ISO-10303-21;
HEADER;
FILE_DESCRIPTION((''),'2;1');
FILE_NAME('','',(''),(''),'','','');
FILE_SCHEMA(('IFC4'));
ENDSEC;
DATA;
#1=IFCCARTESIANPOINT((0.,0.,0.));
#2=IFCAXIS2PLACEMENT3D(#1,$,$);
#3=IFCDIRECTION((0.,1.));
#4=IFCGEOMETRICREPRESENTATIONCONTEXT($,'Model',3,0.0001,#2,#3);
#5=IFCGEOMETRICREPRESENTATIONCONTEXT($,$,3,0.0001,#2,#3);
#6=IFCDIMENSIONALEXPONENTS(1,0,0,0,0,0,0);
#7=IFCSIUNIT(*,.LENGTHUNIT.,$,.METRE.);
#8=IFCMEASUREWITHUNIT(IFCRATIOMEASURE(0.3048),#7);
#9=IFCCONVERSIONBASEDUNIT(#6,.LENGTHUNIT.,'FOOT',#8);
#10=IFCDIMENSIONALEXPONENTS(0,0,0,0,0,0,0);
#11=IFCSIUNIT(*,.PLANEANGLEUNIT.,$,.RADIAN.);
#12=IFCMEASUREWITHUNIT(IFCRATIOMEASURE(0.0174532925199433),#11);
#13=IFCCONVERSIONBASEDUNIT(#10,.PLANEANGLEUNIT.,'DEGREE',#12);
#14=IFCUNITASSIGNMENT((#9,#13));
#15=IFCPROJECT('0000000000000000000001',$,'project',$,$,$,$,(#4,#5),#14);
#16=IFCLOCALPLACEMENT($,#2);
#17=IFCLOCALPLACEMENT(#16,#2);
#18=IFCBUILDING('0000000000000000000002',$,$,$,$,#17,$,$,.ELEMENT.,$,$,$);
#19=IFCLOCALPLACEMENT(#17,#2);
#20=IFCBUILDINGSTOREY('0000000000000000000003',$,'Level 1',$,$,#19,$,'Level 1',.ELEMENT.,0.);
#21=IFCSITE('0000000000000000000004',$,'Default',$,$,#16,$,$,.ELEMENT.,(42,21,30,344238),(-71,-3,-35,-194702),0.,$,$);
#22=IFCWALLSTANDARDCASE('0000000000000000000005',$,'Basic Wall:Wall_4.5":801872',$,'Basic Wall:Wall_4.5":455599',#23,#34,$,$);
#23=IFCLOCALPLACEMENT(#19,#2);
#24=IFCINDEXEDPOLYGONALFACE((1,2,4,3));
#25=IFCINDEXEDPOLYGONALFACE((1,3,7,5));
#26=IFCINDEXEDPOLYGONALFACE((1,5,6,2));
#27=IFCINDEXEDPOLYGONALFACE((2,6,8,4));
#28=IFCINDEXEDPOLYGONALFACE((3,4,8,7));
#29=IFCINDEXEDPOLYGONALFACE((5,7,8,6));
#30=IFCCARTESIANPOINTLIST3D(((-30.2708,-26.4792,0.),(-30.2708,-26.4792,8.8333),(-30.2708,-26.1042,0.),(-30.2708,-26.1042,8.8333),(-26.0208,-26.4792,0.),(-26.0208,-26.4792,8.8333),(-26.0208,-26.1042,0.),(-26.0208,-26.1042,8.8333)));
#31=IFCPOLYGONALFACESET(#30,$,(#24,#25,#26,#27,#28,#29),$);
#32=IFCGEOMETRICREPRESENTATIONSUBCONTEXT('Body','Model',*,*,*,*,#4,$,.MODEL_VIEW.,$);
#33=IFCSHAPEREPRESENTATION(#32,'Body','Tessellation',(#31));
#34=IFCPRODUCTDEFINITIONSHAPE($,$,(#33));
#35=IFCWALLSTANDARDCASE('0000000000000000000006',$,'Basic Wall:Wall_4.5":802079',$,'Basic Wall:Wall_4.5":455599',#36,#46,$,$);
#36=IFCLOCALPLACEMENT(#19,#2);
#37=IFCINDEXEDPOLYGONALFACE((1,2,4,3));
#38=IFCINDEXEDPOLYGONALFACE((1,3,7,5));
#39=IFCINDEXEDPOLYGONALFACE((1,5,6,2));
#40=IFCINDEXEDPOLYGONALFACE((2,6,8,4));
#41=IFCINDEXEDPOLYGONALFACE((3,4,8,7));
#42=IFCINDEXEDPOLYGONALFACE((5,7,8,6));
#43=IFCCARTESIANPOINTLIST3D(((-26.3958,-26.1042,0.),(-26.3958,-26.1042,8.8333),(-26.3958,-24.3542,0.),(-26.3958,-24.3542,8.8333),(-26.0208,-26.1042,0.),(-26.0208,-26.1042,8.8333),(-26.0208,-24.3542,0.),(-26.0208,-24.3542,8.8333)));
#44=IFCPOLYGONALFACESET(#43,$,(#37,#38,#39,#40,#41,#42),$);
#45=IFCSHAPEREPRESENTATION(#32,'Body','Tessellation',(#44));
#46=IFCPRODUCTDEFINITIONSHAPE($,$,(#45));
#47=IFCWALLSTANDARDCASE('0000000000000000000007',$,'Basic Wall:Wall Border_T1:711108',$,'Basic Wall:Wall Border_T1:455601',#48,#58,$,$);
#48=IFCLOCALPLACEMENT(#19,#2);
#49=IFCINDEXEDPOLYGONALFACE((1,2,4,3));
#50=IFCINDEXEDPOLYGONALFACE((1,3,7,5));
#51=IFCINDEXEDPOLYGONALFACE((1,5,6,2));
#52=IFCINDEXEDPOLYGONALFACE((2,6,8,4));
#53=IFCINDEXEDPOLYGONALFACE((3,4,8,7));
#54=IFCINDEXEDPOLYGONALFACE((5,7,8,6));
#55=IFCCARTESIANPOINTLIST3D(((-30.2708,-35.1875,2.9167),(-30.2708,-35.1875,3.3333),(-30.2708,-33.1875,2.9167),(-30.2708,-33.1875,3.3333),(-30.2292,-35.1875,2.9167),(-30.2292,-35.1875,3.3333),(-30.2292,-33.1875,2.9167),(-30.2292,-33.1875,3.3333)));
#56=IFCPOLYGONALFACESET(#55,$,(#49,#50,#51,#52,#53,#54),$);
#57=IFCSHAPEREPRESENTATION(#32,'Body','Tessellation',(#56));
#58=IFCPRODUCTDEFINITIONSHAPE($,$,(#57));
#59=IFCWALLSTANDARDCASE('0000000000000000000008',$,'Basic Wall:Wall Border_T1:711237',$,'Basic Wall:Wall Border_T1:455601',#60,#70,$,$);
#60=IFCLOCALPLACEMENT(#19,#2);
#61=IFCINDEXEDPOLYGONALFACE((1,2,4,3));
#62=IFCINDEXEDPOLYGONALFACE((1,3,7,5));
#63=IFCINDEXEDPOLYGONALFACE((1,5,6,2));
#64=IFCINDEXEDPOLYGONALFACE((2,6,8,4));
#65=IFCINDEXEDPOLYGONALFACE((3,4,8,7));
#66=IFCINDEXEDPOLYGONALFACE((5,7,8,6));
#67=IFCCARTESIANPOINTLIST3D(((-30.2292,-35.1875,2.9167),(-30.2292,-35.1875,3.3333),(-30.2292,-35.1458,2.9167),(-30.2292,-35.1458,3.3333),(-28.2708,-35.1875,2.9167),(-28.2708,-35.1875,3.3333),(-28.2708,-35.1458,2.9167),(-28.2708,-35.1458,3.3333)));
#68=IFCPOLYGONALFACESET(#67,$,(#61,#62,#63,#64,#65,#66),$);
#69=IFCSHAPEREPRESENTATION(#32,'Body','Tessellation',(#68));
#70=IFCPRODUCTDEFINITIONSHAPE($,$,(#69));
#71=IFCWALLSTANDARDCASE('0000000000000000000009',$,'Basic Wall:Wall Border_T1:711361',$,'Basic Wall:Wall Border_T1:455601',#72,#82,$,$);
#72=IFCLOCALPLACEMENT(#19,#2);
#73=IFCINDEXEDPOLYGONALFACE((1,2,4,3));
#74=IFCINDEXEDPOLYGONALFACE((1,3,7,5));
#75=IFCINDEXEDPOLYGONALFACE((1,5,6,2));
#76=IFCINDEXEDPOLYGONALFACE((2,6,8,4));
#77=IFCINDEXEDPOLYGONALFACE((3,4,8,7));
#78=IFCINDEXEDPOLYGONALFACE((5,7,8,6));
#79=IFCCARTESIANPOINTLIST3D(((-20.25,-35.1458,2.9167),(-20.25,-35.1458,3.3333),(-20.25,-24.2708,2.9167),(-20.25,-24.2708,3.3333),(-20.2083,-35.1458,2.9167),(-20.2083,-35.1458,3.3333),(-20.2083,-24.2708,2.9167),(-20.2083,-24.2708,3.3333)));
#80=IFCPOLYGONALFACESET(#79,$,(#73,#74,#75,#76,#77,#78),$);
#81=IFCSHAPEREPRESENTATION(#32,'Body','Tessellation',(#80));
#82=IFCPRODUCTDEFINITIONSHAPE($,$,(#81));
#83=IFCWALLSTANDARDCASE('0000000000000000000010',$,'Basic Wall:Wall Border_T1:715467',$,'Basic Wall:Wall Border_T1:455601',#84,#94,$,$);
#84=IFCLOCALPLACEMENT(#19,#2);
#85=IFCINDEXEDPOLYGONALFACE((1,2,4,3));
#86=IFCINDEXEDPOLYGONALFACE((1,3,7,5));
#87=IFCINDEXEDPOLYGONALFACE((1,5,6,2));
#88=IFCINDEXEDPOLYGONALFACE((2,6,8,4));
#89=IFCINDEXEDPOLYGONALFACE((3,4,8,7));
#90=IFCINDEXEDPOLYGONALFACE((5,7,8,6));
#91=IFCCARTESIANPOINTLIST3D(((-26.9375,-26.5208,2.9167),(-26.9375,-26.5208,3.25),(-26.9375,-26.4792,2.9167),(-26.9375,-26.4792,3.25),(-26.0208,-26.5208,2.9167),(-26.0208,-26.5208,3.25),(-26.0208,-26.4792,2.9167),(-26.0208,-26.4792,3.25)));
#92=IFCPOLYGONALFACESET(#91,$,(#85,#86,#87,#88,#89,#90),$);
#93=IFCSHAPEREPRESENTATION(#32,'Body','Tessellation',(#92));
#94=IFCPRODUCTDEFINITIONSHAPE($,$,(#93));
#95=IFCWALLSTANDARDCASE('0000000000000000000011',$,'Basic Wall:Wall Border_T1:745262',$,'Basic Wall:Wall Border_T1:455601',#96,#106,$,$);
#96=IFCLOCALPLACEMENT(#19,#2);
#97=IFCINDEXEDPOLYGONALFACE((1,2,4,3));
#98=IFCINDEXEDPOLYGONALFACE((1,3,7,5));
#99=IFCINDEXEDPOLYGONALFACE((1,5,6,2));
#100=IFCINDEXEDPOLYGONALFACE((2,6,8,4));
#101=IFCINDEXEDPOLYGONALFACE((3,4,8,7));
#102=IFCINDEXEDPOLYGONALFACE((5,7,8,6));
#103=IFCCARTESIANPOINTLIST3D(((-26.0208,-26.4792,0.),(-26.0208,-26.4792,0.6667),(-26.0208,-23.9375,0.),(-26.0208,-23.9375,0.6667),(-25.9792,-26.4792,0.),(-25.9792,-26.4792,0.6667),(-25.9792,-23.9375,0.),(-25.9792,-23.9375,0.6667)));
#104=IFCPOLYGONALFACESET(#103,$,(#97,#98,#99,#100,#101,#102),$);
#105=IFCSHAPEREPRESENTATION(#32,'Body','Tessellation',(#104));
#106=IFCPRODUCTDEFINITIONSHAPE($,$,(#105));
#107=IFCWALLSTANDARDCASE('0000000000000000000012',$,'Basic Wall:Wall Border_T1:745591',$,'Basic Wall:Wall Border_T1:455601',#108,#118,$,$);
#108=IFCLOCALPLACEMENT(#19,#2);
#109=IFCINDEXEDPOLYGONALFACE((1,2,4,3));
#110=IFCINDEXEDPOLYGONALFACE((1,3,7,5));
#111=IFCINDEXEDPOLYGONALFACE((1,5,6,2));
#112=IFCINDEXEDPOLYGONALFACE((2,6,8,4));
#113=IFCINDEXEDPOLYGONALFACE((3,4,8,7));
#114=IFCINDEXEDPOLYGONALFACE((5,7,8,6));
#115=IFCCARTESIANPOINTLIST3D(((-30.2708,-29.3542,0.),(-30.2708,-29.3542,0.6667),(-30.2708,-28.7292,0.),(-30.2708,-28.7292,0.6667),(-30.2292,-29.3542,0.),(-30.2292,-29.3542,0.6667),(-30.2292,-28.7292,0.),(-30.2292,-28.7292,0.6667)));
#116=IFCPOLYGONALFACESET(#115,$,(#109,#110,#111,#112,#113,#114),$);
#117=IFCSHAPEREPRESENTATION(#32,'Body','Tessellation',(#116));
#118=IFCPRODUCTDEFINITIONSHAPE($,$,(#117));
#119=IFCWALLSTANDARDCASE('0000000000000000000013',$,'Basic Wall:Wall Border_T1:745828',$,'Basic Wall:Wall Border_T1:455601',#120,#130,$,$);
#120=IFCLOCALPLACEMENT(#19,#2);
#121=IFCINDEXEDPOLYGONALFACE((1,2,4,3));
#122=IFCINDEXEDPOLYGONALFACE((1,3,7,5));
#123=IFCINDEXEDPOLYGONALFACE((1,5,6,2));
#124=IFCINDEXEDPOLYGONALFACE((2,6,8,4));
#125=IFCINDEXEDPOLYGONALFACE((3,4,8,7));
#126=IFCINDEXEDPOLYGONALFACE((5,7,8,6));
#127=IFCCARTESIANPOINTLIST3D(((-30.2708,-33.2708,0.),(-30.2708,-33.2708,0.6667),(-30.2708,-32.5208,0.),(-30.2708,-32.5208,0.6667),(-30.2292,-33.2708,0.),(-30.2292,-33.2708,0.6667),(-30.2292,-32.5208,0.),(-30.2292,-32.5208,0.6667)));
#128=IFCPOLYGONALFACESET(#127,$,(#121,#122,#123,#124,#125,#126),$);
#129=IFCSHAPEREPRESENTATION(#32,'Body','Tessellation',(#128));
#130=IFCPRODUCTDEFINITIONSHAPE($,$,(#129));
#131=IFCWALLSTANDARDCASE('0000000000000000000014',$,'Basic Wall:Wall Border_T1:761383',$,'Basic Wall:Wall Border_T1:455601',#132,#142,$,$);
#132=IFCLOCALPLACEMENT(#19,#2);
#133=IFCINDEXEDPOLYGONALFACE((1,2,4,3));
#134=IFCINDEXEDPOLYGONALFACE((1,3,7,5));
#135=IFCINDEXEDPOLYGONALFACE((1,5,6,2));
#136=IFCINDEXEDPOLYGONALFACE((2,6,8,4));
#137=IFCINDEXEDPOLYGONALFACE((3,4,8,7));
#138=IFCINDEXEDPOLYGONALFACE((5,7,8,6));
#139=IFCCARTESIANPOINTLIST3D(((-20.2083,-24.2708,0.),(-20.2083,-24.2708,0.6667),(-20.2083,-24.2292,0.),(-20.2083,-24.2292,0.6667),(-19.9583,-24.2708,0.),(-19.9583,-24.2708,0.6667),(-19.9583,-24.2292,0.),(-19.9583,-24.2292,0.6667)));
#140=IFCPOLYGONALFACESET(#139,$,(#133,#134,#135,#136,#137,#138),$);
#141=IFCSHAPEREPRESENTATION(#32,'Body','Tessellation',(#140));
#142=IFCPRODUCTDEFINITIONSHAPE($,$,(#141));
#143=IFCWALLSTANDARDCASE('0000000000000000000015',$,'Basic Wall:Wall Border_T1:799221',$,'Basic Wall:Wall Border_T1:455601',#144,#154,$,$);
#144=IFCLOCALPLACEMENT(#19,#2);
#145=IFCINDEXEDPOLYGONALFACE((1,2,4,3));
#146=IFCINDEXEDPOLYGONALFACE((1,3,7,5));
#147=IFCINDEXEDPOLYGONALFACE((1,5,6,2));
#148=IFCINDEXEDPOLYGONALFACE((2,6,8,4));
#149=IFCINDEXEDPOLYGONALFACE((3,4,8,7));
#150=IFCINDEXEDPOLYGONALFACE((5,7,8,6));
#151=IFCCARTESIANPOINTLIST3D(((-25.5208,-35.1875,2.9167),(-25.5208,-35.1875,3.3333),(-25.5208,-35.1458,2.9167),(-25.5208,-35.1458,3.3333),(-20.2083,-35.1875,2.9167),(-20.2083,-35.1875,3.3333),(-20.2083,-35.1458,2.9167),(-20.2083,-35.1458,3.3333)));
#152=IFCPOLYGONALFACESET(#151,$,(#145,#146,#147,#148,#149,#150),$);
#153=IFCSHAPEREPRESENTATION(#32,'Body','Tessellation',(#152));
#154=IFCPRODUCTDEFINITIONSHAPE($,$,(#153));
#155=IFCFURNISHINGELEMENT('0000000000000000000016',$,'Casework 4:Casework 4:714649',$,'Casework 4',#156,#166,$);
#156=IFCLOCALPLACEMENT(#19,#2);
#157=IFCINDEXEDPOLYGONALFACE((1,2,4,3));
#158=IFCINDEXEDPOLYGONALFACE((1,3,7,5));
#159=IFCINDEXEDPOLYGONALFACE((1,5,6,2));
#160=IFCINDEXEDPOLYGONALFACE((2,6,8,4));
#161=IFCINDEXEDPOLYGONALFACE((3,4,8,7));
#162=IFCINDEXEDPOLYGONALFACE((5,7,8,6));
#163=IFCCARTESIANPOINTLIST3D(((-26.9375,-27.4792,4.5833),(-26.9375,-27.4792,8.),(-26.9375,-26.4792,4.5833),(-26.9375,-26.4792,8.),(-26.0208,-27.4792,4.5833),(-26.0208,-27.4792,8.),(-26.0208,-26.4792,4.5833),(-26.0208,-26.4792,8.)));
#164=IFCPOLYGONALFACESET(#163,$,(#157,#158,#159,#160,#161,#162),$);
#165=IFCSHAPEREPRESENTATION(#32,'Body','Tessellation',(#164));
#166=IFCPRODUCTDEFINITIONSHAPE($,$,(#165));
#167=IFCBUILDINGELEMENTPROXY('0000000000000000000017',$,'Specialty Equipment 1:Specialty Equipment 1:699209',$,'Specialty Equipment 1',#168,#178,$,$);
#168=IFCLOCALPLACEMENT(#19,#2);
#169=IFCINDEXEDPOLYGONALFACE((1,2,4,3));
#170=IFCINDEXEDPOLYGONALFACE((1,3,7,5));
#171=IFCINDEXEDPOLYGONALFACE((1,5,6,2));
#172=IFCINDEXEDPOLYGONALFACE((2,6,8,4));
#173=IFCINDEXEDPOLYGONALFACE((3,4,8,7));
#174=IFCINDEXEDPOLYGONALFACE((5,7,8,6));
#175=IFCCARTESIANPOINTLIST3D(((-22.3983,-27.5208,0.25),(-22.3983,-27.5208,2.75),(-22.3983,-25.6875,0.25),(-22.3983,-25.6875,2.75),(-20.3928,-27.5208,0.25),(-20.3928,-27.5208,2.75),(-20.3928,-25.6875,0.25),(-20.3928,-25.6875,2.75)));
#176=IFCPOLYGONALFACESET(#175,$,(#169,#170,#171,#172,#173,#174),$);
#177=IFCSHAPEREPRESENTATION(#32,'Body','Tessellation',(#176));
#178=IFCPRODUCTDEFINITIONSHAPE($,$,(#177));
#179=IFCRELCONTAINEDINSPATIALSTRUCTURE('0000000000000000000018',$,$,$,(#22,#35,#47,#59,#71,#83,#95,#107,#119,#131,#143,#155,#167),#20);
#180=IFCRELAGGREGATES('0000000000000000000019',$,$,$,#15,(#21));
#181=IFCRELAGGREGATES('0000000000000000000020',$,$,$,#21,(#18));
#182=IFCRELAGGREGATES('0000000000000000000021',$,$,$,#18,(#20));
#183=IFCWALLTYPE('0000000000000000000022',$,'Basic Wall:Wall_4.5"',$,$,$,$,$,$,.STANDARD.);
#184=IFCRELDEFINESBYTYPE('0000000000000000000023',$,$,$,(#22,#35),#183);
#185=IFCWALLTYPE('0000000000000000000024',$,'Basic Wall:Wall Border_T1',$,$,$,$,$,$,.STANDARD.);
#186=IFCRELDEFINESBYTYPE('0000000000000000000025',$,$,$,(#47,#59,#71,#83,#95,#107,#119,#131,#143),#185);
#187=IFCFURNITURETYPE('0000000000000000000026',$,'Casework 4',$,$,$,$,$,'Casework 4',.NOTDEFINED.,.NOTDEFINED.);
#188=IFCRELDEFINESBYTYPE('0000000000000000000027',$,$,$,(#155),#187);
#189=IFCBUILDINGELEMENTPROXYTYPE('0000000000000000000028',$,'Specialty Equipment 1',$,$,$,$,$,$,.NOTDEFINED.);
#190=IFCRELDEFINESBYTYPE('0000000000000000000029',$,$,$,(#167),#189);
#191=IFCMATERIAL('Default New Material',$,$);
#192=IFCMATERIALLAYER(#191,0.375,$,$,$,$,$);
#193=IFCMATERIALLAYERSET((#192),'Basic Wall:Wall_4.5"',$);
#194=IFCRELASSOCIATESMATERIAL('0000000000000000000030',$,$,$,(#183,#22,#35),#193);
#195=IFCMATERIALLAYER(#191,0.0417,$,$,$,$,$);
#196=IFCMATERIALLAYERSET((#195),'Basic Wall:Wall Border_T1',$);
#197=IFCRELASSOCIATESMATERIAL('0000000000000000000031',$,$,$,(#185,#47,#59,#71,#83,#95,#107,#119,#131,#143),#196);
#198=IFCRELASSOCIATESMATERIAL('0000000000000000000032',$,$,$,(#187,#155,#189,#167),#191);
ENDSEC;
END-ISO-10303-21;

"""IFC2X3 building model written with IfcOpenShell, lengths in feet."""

from ifc_helpers import new_model, entity, si_unit, converted_unit, direction, frame, frame_2d, origin, place, context, subcontext, project, spatial, rectangle, extrude, source, transform, mapped, material, layer, layer_set, layer_usage, type_object, type_shapes, element, save


model = new_model("IFC2X3")

# Units and contexts
model_context = context("Model", 3, precision=0.0001, world=origin(), true_north=direction((0.0, 1.0)))
context_of_model = context(None, 3, precision=0.0001, world=origin(), true_north=direction((0.0, 1.0)))
body_context = subcontext(model_context, "Body", "Model", "MODEL_VIEW")
ifc_project = project(units=[converted_unit("LENGTHUNIT", "FOOT", entity("IfcRatioMeasure", 0.3048), si_unit("LENGTHUNIT", "METRE"), dimensions=[1, 0, 0, 0, 0, 0, 0]), converted_unit("PLANEANGLEUNIT", "DEGREE", entity("IfcRatioMeasure", 0.0174532925199433), si_unit("PLANEANGLEUNIT", "RADIAN"), dimensions=[0, 0, 0, 0, 0, 0, 0])], contexts=[model_context, context_of_model])

# Site, building, storey
site_placement = place(None, origin())
site = spatial("IfcSite", under=ifc_project, at=site_placement, Name="Default", CompositionType="ELEMENT", RefLatitude=(42, 21, 30, 344238), RefLongitude=(-71, -3, -35, -194702), RefElevation=0.0)
building_placement = place(site_placement, origin())
building = spatial("IfcBuilding", under=site, at=building_placement, CompositionType="ELEMENT")
storey_placement = place(building_placement, origin())
storey = spatial("IfcBuildingStorey", under=building, at=storey_placement, Name="Level 1", LongName="Level 1", CompositionType="ELEMENT", Elevation=0.0)

# Shared definitions
ifc_material = material(Name="Default New Material")

# Wall
ifc_layer_1 = layer(ifc_material, 0.375)
ifc_layer_set_1 = layer_set([ifc_layer_1], Name="Basic Wall:Wall_4.5\"")
ifc_layer_usage_1 = layer_usage(ifc_layer_set_1, "AXIS2", "NEGATIVE", 0.1875)
wall_type_1 = type_object("IfcWallType", Name="Basic Wall:Wall_4.5\"", PredefinedType="STANDARD", material=ifc_layer_set_1)
wall_1_placement = place(storey_placement, frame((-30.2708, -26.2917, 0.0)))
element("IfcWallStandardCase", 1, at=wall_1_placement, inside=storey, type_object=wall_type_1, material=ifc_layer_usage_1, Name="Basic Wall:Wall_4.5\":801872", ObjectType="Basic Wall:Wall_4.5\":455599", context=body_context, shape_type="SweptSolid", body=[
    extrude(rectangle(XDim=4.25, YDim=0.375, at=frame_2d((2.125, 0.0), x_axis=(-1.0, 0.0))), origin(), (0.0, 0.0, 1.0), 8.8333),
])

# Walls
ifc_layer_usage_2 = layer_usage(ifc_layer_set_1, "AXIS2", "POSITIVE", -0.1875)
wall_2_placement = place(storey_placement, frame((-26.2083, -24.3542, 0.0), z_axis=(0.0, 0.0, 1.0), x_axis=(0.0, -1.0, 0.0)))
element("IfcWallStandardCase", 2, at=wall_2_placement, inside=storey, type_object=wall_type_1, material=ifc_layer_usage_2, Name="Basic Wall:Wall_4.5\":802079", ObjectType="Basic Wall:Wall_4.5\":455599", context=body_context, shape_type="SweptSolid", body=[
    extrude(rectangle(XDim=1.75, YDim=0.375, at=frame_2d((0.875, 0.0), x_axis=(-1.0, 0.0))), origin(), (0.0, 0.0, 1.0), 8.8333),
])
ifc_layer_2 = layer(ifc_material, 0.0417)
ifc_layer_set_2 = layer_set([ifc_layer_2], Name="Basic Wall:Wall Border_T1")
ifc_layer_usage_3 = layer_usage(ifc_layer_set_2, "AXIS2", "NEGATIVE", 0.0208)
wall_type_2 = type_object("IfcWallType", Name="Basic Wall:Wall Border_T1", PredefinedType="STANDARD", material=ifc_layer_set_2)
wall_3_placement = place(storey_placement, frame((-30.25, -33.1875, 2.9167), z_axis=(0.0, 0.0, 1.0), x_axis=(0.0, -1.0, 0.0)))
element("IfcWallStandardCase", 3, at=wall_3_placement, inside=storey, type_object=wall_type_2, material=ifc_layer_usage_3, Name="Basic Wall:Wall Border_T1:711108", ObjectType="Basic Wall:Wall Border_T1:455601", context=body_context, shape_type="SweptSolid", body=[
    extrude(rectangle(XDim=2.0, YDim=0.0417, at=frame_2d((1.0, 0.0), x_axis=(-1.0, 0.0))), origin(), (0.0, 0.0, 1.0), 0.4167),
])
ifc_layer_usage_4 = layer_usage(ifc_layer_set_2, "AXIS2", "NEGATIVE", 0.0208)
wall_4_placement = place(storey_placement, frame((-30.2292, -35.1667, 2.9167)))
element("IfcWallStandardCase", 4, at=wall_4_placement, inside=storey, type_object=wall_type_2, material=ifc_layer_usage_4, Name="Basic Wall:Wall Border_T1:711237", ObjectType="Basic Wall:Wall Border_T1:455601", context=body_context, shape_type="SweptSolid", body=[
    extrude(rectangle(XDim=1.9583, YDim=0.0417, at=frame_2d((0.9792, 0.0), x_axis=(-1.0, 0.0))), origin(), (0.0, 0.0, 1.0), 0.4167),
])
ifc_layer_usage_5 = layer_usage(ifc_layer_set_2, "AXIS2", "NEGATIVE", 0.0208)
wall_5_placement = place(storey_placement, frame((-20.2292, -35.1458, 2.9167), z_axis=(0.0, 0.0, 1.0), x_axis=(0.0, 1.0, 0.0)))
element("IfcWallStandardCase", 5, at=wall_5_placement, inside=storey, type_object=wall_type_2, material=ifc_layer_usage_5, Name="Basic Wall:Wall Border_T1:711361", ObjectType="Basic Wall:Wall Border_T1:455601", context=body_context, shape_type="SweptSolid", body=[
    extrude(rectangle(XDim=10.875, YDim=0.0417, at=frame_2d((5.4375, 0.0), x_axis=(-1.0, 0.0))), origin(), (0.0, 0.0, 1.0), 0.4167),
])
ifc_layer_usage_6 = layer_usage(ifc_layer_set_2, "AXIS2", "POSITIVE", -0.0208)
wall_6_placement = place(storey_placement, frame((-26.9375, -26.5, 2.9167)))
element("IfcWallStandardCase", 6, at=wall_6_placement, inside=storey, type_object=wall_type_2, material=ifc_layer_usage_6, Name="Basic Wall:Wall Border_T1:715467", ObjectType="Basic Wall:Wall Border_T1:455601", context=body_context, shape_type="SweptSolid", body=[
    extrude(rectangle(XDim=0.9167, YDim=0.0417, at=frame_2d((0.4583, 0.0), x_axis=(-1.0, 0.0))), origin(), (0.0, 0.0, 1.0), 0.3333),
])
ifc_layer_usage_7 = layer_usage(ifc_layer_set_2, "AXIS2", "POSITIVE", -0.0208)
wall_7_placement = place(storey_placement, frame((-26.0, -26.4792, 0.0), z_axis=(0.0, 0.0, 1.0), x_axis=(0.0, 1.0, 0.0)))
element("IfcWallStandardCase", 7, at=wall_7_placement, inside=storey, type_object=wall_type_2, material=ifc_layer_usage_7, Name="Basic Wall:Wall Border_T1:745262", ObjectType="Basic Wall:Wall Border_T1:455601", context=body_context, shape_type="SweptSolid", body=[
    extrude(rectangle(XDim=2.5417, YDim=0.0417, at=frame_2d((1.2708, 0.0), x_axis=(-1.0, 0.0))), origin(), (0.0, 0.0, 1.0), 0.6667),
])
ifc_layer_usage_8 = layer_usage(ifc_layer_set_2, "AXIS2", "POSITIVE", -0.0208)
wall_8_placement = place(storey_placement, frame((-30.25, -29.3542, 0.0), z_axis=(0.0, 0.0, 1.0), x_axis=(0.0, 1.0, 0.0)))
element("IfcWallStandardCase", 8, at=wall_8_placement, inside=storey, type_object=wall_type_2, material=ifc_layer_usage_8, Name="Basic Wall:Wall Border_T1:745591", ObjectType="Basic Wall:Wall Border_T1:455601", context=body_context, shape_type="SweptSolid", body=[
    extrude(rectangle(XDim=0.625, YDim=0.0417, at=frame_2d((0.3125, 0.0), x_axis=(-1.0, 0.0))), origin(), (0.0, 0.0, 1.0), 0.6667),
])
ifc_layer_usage_9 = layer_usage(ifc_layer_set_2, "AXIS2", "POSITIVE", -0.0208)
wall_9_placement = place(storey_placement, frame((-30.25, -33.2708, 0.0), z_axis=(0.0, 0.0, 1.0), x_axis=(0.0, 1.0, 0.0)))
element("IfcWallStandardCase", 9, at=wall_9_placement, inside=storey, type_object=wall_type_2, material=ifc_layer_usage_9, Name="Basic Wall:Wall Border_T1:745828", ObjectType="Basic Wall:Wall Border_T1:455601", context=body_context, shape_type="SweptSolid", body=[
    extrude(rectangle(XDim=0.75, YDim=0.0417, at=frame_2d((0.375, 0.0), x_axis=(-1.0, 0.0))), origin(), (0.0, 0.0, 1.0), 0.6667),
])
ifc_layer_usage_10 = layer_usage(ifc_layer_set_2, "AXIS2", "NEGATIVE", 0.0208)
wall_10_placement = place(storey_placement, frame((-20.2083, -24.25, 0.0)))
element("IfcWallStandardCase", 10, at=wall_10_placement, inside=storey, type_object=wall_type_2, material=ifc_layer_usage_10, Name="Basic Wall:Wall Border_T1:761383", ObjectType="Basic Wall:Wall Border_T1:455601", context=body_context, shape_type="SweptSolid", body=[
    extrude(rectangle(XDim=0.25, YDim=0.0417, at=frame_2d((0.125, 0.0), x_axis=(-1.0, 0.0))), origin(), (0.0, 0.0, 1.0), 0.6667),
])
ifc_layer_usage_11 = layer_usage(ifc_layer_set_2, "AXIS2", "NEGATIVE", 0.0208)
wall_11_placement = place(storey_placement, frame((-25.5208, -35.1667, 2.9167)))
element("IfcWallStandardCase", 11, at=wall_11_placement, inside=storey, type_object=wall_type_2, material=ifc_layer_usage_11, Name="Basic Wall:Wall Border_T1:799221", ObjectType="Basic Wall:Wall Border_T1:455601", context=body_context, shape_type="SweptSolid", body=[
    extrude(rectangle(XDim=5.3125, YDim=0.0417, at=frame_2d((2.6563, 0.0), x_axis=(-1.0, 0.0))), origin(), (0.0, 0.0, 1.0), 0.4167),
])

# Furnishing element
furniture_type = type_object("IfcFurnitureType", Name="Casework 4", ElementType="Casework 4", AssemblyPlace="NOTDEFINED", material=ifc_material)
shared_shape_1 = source(origin(), body_context, "Body", "SweptSolid", [
    extrude(rectangle(XDim=1.0, YDim=0.9167, at=frame_2d((0.0, 0.0), x_axis=(1.0, 0.0))), frame((0.4583, 0.5, 0.0), z_axis=(0.0, 0.0, 1.0), x_axis=(0.0, 1.0, 0.0)), (0.0, 0.0, 1.0), 3.4167),
])
type_shapes(furniture_type, [shared_shape_1])
furnishing_placement = place(storey_placement, frame((-26.9375, -27.4792, 4.5833)))
element("IfcFurnishingElement", 12, at=furnishing_placement, inside=storey, type_object=furniture_type, material=ifc_material, Name="Casework 4:Casework 4:714649", ObjectType="Casework 4", context=body_context, shape_type="MappedRepresentation", body=[
    mapped(shared_shape_1, transform((0.0, 0.0, 0.0), scale=1.0)),
])

# Building element proxy
building_element_proxy_type_1 = type_object("IfcBuildingElementProxyType", Name="Specialty Equipment 1", PredefinedType="NOTDEFINED", material=ifc_material)
shared_shape_2 = source(origin(), body_context, "Body", "SweptSolid", [
    extrude(rectangle(XDim=2.0056, YDim=1.8333, at=frame_2d((0.0, 0.0), x_axis=(1.0, 0.0))), frame((1.0028, 0.9167, 0.0)), (0.0, 0.0, 1.0), 2.5),
])
type_shapes(building_element_proxy_type_1, [shared_shape_2])
proxy_1_placement = place(storey_placement, frame((-22.3983, -27.5208, 0.25)))
element("IfcBuildingElementProxy", 13, at=proxy_1_placement, inside=storey, type_object=building_element_proxy_type_1, material=ifc_material, Name="Specialty Equipment 1:Specialty Equipment 1:699209", ObjectType="Specialty Equipment 1", context=body_context, shape_type="MappedRepresentation", body=[
    mapped(shared_shape_2, transform((0.0, 0.0, 0.0), scale=1.0)),
])

save(model, "model.ifc")
